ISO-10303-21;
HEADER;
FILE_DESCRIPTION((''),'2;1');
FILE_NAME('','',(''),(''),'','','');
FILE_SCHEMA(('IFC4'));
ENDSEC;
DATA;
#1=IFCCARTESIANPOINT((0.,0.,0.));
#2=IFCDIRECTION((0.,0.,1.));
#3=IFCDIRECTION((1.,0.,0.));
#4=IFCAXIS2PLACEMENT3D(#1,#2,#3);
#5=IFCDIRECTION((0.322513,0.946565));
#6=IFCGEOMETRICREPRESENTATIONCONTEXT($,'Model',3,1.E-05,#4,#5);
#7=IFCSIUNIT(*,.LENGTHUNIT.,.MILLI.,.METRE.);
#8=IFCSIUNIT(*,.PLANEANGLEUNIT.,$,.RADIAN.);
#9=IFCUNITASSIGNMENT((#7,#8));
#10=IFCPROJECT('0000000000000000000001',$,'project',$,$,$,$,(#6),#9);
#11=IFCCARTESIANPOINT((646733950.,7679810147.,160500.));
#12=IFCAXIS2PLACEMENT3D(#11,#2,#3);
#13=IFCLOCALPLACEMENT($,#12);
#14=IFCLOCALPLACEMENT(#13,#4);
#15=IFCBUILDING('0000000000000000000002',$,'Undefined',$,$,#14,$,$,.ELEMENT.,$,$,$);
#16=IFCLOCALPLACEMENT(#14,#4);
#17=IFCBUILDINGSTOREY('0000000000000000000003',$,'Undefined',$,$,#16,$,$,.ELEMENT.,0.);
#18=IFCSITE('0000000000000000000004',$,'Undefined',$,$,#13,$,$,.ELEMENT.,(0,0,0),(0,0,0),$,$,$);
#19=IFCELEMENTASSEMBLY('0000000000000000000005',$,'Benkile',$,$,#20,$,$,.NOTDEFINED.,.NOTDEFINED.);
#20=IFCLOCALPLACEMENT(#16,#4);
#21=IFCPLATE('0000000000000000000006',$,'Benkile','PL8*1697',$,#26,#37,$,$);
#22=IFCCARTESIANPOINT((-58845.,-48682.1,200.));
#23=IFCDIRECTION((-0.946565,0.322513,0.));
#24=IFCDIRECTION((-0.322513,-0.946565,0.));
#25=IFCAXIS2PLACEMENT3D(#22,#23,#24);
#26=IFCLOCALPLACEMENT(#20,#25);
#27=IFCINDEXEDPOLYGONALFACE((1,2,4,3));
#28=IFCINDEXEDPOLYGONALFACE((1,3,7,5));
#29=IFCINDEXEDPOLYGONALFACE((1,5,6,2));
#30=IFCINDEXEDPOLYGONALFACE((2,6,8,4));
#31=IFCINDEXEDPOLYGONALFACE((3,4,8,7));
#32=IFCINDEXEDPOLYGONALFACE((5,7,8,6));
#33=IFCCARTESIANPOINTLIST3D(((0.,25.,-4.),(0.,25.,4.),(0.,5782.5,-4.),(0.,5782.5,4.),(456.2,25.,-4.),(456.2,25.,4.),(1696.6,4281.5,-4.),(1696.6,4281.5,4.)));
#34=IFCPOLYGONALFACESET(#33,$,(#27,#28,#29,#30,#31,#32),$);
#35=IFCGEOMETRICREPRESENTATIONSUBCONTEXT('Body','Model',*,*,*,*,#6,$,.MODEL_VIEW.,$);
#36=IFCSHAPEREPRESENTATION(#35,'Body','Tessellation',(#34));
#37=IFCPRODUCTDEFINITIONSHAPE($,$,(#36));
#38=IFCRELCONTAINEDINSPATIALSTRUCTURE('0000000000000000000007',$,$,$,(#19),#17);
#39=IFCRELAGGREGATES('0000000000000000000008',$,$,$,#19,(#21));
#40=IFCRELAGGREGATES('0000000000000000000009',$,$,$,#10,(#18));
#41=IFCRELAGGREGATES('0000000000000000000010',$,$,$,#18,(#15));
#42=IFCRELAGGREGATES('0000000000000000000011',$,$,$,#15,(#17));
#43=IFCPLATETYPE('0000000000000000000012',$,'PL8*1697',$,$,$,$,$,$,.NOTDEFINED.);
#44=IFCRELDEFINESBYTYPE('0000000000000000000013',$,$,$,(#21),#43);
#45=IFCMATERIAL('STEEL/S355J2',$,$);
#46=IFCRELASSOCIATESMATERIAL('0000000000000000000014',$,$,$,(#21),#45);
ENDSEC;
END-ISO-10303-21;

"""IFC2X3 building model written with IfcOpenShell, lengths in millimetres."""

from ifc_helpers import new_model, si_unit, direction, frame, origin_with_axes, place, context, subcontext, project, spatial, polyline, outline, extrude, clip, halfspace, material, type_object, element, aggregate, save


model = new_model("IFC2X3")

# Units and contexts
model_context = context("Model", 3, precision=1e-05, world=origin_with_axes(), true_north=direction((0.322513, 0.946565)))
body_context = subcontext(model_context, "Body", "Model", "MODEL_VIEW")
ifc_project = project(units=[si_unit("LENGTHUNIT", "METRE", prefix="MILLI"), si_unit("PLANEANGLEUNIT", "RADIAN")], contexts=[model_context])

# Site, building, storey
site_placement = place(None, frame((646733950.0, 7679810147.0, 160500.0), z_axis=(0.0, 0.0, 1.0), x_axis=(1.0, 0.0, 0.0)))
site = spatial("IfcSite", under=ifc_project, at=site_placement, Name="Undefined", CompositionType="ELEMENT", RefLatitude=(0, 0, 0), RefLongitude=(0, 0, 0))
building_placement = place(site_placement, origin_with_axes())
building = spatial("IfcBuilding", under=site, at=building_placement, Name="Undefined", CompositionType="ELEMENT")
storey_placement = place(building_placement, origin_with_axes())
storey = spatial("IfcBuildingStorey", under=building, at=storey_placement, Name="Undefined", CompositionType="ELEMENT", Elevation=0.0)

# Element assembly
assembly_1_placement = place(storey_placement, origin_with_axes())
assembly_1 = element("IfcElementAssembly", 1, at=assembly_1_placement, inside=storey, Name="Benkile", AssemblyPlace="NOTDEFINED", PredefinedType="NOTDEFINED")
ifc_material_1 = material(Name="STEEL/S355J2")

# Plate
plate_type_1 = type_object("IfcPlateType", Name="PL8*1697", PredefinedType="NOTDEFINED")
plate_1_placement = place(assembly_1_placement, frame((-58845.0, -48682.1, 200.0), z_axis=(-0.946565, 0.322513, 0.0), x_axis=(-0.322513, -0.946565, 0.0)))
plate_1 = element("IfcPlate", 2, at=plate_1_placement, type_object=plate_type_1, material=ifc_material_1, Name="Benkile", Description="PL8*1697", context=body_context, shape_type="Clipping", body=[
    clip(extrude(outline(polyline([(0.0, 0.0), (449.0, 0.0), (1696.6, 4281.5), (0.0, 5782.5), (0.0, 0.0)])), frame((0.0, 0.0, -4.0), z_axis=(0.0, 0.0, 1.0), x_axis=(1.0, 0.0, 0.0)), (0.0, 0.0, 1.0), 8.0), halfspace(frame((0.0, 25.0, -4.0), z_axis=(0.0, -1.0, 0.0), x_axis=(0.0, 0.0, 1.0)), False)),
])

aggregate(assembly_1, [plate_1])

save(model, "model.ifc")
